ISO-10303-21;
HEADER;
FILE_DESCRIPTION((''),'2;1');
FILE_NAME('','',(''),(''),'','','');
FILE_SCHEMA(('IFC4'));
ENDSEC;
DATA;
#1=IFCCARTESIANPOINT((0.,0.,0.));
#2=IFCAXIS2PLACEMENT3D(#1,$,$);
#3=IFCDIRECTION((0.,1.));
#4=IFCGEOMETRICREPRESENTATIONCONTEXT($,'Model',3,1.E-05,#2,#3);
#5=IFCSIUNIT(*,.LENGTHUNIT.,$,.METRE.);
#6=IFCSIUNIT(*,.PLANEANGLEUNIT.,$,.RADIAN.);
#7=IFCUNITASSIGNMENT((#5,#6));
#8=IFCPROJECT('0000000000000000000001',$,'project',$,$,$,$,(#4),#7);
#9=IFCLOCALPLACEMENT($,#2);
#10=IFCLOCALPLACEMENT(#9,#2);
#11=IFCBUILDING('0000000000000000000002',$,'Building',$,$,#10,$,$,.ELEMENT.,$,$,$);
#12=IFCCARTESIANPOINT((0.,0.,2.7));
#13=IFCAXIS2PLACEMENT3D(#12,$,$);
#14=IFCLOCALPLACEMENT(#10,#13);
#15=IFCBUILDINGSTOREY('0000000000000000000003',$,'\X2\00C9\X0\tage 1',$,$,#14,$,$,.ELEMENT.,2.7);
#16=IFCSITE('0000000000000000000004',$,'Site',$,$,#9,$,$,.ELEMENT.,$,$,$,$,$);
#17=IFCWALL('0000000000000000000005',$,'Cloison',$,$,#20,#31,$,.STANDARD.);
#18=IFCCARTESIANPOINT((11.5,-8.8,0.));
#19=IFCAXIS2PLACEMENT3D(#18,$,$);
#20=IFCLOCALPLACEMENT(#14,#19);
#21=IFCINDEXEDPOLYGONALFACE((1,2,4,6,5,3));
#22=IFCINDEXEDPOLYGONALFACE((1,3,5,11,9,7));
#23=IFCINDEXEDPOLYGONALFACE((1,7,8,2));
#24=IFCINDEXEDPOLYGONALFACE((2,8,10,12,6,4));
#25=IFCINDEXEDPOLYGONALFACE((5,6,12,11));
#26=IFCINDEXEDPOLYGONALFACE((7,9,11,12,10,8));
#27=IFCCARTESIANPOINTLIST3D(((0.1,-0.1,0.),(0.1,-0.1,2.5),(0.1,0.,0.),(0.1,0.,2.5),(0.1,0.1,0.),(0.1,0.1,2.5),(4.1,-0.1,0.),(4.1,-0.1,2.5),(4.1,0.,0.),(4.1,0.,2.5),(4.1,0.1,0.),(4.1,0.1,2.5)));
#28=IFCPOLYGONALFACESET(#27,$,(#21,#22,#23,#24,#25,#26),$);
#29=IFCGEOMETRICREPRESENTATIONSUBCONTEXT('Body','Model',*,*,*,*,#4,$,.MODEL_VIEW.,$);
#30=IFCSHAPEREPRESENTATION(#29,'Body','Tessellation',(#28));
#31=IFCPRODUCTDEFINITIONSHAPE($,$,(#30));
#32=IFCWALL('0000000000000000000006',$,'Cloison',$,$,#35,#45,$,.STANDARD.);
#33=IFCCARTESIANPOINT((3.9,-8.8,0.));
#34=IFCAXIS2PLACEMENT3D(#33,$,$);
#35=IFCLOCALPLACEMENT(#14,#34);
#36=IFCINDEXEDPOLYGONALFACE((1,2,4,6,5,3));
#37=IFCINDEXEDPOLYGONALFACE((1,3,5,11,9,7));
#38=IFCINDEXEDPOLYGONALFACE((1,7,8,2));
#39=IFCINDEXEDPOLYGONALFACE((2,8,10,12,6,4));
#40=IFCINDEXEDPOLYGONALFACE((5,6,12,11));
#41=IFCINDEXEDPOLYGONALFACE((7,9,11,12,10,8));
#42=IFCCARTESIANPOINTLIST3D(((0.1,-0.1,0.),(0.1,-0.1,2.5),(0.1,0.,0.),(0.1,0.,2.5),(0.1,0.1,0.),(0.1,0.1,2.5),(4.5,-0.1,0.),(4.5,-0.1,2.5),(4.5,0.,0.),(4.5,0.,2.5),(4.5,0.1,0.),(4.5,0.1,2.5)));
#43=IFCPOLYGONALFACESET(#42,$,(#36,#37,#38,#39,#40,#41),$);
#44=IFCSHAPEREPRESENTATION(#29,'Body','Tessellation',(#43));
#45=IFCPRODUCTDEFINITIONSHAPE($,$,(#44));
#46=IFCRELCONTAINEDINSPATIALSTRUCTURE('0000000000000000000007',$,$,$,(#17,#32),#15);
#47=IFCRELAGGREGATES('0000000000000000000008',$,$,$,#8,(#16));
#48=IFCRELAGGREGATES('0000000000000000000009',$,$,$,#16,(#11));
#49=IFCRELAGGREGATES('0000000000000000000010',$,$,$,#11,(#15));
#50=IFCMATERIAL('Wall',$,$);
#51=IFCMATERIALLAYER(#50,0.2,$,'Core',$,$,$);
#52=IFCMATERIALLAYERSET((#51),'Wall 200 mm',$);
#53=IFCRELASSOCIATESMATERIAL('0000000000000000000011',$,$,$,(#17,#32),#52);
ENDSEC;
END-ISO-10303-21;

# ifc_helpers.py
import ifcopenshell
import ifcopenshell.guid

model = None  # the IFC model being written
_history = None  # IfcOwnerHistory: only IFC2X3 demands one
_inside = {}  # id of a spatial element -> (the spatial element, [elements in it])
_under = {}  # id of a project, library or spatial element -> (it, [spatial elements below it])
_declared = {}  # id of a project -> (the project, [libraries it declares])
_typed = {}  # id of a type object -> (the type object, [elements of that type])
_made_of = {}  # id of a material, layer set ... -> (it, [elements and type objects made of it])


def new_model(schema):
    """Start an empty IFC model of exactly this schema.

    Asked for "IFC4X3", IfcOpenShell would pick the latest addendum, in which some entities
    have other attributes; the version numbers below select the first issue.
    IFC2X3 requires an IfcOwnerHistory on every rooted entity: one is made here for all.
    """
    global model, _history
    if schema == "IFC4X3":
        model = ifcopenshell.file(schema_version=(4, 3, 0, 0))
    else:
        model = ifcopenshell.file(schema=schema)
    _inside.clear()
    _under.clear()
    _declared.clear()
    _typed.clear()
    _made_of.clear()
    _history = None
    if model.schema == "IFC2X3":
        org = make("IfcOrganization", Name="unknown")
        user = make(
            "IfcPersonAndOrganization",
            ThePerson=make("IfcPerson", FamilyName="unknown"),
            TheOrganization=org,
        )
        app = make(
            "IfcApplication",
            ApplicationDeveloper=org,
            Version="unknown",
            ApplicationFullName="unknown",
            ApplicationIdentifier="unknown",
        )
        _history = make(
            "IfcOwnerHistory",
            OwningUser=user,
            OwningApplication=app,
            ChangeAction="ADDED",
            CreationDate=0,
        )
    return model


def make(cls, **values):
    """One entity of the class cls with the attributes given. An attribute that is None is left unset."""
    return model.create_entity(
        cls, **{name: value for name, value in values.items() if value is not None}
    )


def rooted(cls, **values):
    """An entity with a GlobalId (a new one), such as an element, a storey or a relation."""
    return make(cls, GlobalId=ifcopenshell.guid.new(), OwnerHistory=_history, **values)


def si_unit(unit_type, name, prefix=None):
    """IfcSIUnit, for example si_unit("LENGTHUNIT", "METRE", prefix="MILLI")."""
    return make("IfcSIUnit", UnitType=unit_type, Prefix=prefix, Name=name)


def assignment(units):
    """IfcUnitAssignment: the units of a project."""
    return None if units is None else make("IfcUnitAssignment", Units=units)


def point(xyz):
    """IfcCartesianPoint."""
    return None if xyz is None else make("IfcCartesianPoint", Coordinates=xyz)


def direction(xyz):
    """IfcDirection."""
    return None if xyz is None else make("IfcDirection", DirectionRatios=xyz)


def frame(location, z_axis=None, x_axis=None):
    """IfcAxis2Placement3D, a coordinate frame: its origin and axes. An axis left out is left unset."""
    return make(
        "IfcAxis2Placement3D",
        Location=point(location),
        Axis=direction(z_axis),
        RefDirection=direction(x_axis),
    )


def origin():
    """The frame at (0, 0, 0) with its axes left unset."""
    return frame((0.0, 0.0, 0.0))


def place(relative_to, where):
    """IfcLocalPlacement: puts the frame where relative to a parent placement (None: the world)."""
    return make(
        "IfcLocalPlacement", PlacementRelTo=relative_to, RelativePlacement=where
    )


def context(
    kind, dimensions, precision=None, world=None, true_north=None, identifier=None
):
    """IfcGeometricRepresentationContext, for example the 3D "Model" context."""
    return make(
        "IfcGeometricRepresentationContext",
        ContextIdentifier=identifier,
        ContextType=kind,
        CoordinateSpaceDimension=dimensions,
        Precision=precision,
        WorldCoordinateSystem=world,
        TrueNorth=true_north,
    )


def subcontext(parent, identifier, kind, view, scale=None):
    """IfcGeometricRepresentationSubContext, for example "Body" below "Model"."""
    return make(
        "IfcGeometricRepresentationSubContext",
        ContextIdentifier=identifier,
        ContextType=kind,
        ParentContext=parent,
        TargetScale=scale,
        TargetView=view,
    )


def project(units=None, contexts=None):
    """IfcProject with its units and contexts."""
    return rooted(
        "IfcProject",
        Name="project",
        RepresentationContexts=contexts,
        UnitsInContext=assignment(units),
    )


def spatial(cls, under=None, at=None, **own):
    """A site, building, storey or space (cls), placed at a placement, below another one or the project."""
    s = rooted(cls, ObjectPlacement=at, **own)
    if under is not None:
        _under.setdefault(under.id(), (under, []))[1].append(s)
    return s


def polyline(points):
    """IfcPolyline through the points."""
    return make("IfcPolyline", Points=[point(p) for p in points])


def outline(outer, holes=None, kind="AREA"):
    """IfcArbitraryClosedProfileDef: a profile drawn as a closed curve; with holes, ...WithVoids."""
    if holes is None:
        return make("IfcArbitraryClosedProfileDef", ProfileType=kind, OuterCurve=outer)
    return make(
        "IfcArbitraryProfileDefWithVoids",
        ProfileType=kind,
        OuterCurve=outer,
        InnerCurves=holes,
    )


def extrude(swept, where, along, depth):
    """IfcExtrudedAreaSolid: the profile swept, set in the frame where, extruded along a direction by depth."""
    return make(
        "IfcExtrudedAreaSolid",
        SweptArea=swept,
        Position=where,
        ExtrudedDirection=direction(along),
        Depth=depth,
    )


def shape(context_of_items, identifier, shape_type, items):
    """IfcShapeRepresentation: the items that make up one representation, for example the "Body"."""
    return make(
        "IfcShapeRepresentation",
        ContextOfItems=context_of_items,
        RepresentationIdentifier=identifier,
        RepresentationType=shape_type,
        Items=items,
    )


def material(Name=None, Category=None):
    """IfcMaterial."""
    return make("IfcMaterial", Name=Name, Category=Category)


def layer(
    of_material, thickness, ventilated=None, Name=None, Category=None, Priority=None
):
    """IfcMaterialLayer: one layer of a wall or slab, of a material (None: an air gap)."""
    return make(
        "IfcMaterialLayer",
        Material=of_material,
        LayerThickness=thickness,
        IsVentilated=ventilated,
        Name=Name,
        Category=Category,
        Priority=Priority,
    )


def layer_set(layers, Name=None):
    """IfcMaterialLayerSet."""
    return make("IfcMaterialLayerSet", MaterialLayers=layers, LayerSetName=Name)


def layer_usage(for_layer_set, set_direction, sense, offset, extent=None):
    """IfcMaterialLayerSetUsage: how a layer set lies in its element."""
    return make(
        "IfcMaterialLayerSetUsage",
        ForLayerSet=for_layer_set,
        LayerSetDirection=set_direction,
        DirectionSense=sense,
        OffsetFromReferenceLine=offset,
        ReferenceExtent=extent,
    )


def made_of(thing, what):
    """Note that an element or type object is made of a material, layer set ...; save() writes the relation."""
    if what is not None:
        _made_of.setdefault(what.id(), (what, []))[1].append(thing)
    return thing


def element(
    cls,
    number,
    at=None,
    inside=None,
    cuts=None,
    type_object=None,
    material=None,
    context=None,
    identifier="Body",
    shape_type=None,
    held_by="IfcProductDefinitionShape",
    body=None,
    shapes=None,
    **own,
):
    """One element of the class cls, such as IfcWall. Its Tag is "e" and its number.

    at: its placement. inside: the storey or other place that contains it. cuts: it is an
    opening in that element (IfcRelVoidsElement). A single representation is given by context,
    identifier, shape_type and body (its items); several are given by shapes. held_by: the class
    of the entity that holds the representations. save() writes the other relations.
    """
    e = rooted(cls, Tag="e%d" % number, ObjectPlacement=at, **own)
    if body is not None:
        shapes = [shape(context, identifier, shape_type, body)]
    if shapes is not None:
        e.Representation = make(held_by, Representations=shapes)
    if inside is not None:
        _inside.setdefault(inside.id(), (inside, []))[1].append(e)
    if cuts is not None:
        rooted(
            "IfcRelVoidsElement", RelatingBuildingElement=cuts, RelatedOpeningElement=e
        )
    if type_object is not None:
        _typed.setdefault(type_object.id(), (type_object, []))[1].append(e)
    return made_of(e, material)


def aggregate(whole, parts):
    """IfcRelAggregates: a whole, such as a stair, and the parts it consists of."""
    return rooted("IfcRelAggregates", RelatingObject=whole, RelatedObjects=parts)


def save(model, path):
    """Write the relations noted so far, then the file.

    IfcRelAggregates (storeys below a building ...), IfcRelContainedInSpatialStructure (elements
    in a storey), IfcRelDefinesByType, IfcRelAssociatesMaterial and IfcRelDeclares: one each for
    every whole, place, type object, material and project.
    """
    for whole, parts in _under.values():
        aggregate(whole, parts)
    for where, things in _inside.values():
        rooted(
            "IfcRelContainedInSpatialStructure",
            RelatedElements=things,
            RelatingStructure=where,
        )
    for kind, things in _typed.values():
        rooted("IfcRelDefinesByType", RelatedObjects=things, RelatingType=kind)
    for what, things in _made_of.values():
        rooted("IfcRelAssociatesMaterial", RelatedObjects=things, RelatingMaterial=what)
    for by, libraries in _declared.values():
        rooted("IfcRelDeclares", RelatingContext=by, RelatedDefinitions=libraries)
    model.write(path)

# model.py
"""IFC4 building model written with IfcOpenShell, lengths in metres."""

from ifc_helpers import new_model, si_unit, direction, frame, origin, place, context, subcontext, project, spatial, polyline, outline, extrude, material, layer, layer_set, layer_usage, element, save


model = new_model("IFC4")

# Units and contexts
model_context = context("Model", 3, precision=1e-05, world=origin(), true_north=direction((0.0, 1.0)))
body_context = subcontext(model_context, "Body", "Model", "MODEL_VIEW")
ifc_project = project(units=[si_unit("LENGTHUNIT", "METRE"), si_unit("PLANEANGLEUNIT", "RADIAN")], contexts=[model_context])

# Site, building, storey
site_placement = place(None, origin())
site = spatial("IfcSite", under=ifc_project, at=site_placement, Name="Site", CompositionType="ELEMENT")
building_placement = place(site_placement, origin())
building = spatial("IfcBuilding", under=site, at=building_placement, Name="Building", CompositionType="ELEMENT")
storey_placement = place(building_placement, frame((0.0, 0.0, 2.7)))
storey = spatial("IfcBuildingStorey", under=building, at=storey_placement, Name="Étage 1", CompositionType="ELEMENT", Elevation=2.7)

# Shared definitions
ifc_material = material(Name="Wall")
ifc_layer = layer(ifc_material, 0.2, Name="Core")
ifc_layer_set = layer_set([ifc_layer], Name="Wall 200 mm")
ifc_layer_usage = layer_usage(ifc_layer_set, "AXIS2", "POSITIVE", -0.1)

# Walls
wall_1_placement = place(storey_placement, frame((11.5, -8.8, 0.0)))
element("IfcWall", 1, at=wall_1_placement, inside=storey, material=ifc_layer_usage, Name="Cloison", PredefinedType="STANDARD", context=body_context, shape_type="SweptSolid", body=[
    extrude(outline(polyline([(0.1, 0.0), (0.1, -0.1), (4.1, -0.1), (4.1, 0.0), (4.1, 0.1), (0.1, 0.1), (0.1, 0.0)])), origin(), (0.0, 0.0, 1.0), 2.5),
])
wall_2_placement = place(storey_placement, frame((3.9, -8.8, 0.0)))
element("IfcWall", 2, at=wall_2_placement, inside=storey, material=ifc_layer_usage, Name="Cloison", PredefinedType="STANDARD", context=body_context, shape_type="SweptSolid", body=[
    extrude(outline(polyline([(0.1, 0.0), (0.1, -0.1), (4.5, -0.1), (4.5, 0.0), (4.5, 0.1), (0.1, 0.1), (0.1, 0.0)])), origin(), (0.0, 0.0, 1.0), 2.5),
])

save(model, "model.ifc")
